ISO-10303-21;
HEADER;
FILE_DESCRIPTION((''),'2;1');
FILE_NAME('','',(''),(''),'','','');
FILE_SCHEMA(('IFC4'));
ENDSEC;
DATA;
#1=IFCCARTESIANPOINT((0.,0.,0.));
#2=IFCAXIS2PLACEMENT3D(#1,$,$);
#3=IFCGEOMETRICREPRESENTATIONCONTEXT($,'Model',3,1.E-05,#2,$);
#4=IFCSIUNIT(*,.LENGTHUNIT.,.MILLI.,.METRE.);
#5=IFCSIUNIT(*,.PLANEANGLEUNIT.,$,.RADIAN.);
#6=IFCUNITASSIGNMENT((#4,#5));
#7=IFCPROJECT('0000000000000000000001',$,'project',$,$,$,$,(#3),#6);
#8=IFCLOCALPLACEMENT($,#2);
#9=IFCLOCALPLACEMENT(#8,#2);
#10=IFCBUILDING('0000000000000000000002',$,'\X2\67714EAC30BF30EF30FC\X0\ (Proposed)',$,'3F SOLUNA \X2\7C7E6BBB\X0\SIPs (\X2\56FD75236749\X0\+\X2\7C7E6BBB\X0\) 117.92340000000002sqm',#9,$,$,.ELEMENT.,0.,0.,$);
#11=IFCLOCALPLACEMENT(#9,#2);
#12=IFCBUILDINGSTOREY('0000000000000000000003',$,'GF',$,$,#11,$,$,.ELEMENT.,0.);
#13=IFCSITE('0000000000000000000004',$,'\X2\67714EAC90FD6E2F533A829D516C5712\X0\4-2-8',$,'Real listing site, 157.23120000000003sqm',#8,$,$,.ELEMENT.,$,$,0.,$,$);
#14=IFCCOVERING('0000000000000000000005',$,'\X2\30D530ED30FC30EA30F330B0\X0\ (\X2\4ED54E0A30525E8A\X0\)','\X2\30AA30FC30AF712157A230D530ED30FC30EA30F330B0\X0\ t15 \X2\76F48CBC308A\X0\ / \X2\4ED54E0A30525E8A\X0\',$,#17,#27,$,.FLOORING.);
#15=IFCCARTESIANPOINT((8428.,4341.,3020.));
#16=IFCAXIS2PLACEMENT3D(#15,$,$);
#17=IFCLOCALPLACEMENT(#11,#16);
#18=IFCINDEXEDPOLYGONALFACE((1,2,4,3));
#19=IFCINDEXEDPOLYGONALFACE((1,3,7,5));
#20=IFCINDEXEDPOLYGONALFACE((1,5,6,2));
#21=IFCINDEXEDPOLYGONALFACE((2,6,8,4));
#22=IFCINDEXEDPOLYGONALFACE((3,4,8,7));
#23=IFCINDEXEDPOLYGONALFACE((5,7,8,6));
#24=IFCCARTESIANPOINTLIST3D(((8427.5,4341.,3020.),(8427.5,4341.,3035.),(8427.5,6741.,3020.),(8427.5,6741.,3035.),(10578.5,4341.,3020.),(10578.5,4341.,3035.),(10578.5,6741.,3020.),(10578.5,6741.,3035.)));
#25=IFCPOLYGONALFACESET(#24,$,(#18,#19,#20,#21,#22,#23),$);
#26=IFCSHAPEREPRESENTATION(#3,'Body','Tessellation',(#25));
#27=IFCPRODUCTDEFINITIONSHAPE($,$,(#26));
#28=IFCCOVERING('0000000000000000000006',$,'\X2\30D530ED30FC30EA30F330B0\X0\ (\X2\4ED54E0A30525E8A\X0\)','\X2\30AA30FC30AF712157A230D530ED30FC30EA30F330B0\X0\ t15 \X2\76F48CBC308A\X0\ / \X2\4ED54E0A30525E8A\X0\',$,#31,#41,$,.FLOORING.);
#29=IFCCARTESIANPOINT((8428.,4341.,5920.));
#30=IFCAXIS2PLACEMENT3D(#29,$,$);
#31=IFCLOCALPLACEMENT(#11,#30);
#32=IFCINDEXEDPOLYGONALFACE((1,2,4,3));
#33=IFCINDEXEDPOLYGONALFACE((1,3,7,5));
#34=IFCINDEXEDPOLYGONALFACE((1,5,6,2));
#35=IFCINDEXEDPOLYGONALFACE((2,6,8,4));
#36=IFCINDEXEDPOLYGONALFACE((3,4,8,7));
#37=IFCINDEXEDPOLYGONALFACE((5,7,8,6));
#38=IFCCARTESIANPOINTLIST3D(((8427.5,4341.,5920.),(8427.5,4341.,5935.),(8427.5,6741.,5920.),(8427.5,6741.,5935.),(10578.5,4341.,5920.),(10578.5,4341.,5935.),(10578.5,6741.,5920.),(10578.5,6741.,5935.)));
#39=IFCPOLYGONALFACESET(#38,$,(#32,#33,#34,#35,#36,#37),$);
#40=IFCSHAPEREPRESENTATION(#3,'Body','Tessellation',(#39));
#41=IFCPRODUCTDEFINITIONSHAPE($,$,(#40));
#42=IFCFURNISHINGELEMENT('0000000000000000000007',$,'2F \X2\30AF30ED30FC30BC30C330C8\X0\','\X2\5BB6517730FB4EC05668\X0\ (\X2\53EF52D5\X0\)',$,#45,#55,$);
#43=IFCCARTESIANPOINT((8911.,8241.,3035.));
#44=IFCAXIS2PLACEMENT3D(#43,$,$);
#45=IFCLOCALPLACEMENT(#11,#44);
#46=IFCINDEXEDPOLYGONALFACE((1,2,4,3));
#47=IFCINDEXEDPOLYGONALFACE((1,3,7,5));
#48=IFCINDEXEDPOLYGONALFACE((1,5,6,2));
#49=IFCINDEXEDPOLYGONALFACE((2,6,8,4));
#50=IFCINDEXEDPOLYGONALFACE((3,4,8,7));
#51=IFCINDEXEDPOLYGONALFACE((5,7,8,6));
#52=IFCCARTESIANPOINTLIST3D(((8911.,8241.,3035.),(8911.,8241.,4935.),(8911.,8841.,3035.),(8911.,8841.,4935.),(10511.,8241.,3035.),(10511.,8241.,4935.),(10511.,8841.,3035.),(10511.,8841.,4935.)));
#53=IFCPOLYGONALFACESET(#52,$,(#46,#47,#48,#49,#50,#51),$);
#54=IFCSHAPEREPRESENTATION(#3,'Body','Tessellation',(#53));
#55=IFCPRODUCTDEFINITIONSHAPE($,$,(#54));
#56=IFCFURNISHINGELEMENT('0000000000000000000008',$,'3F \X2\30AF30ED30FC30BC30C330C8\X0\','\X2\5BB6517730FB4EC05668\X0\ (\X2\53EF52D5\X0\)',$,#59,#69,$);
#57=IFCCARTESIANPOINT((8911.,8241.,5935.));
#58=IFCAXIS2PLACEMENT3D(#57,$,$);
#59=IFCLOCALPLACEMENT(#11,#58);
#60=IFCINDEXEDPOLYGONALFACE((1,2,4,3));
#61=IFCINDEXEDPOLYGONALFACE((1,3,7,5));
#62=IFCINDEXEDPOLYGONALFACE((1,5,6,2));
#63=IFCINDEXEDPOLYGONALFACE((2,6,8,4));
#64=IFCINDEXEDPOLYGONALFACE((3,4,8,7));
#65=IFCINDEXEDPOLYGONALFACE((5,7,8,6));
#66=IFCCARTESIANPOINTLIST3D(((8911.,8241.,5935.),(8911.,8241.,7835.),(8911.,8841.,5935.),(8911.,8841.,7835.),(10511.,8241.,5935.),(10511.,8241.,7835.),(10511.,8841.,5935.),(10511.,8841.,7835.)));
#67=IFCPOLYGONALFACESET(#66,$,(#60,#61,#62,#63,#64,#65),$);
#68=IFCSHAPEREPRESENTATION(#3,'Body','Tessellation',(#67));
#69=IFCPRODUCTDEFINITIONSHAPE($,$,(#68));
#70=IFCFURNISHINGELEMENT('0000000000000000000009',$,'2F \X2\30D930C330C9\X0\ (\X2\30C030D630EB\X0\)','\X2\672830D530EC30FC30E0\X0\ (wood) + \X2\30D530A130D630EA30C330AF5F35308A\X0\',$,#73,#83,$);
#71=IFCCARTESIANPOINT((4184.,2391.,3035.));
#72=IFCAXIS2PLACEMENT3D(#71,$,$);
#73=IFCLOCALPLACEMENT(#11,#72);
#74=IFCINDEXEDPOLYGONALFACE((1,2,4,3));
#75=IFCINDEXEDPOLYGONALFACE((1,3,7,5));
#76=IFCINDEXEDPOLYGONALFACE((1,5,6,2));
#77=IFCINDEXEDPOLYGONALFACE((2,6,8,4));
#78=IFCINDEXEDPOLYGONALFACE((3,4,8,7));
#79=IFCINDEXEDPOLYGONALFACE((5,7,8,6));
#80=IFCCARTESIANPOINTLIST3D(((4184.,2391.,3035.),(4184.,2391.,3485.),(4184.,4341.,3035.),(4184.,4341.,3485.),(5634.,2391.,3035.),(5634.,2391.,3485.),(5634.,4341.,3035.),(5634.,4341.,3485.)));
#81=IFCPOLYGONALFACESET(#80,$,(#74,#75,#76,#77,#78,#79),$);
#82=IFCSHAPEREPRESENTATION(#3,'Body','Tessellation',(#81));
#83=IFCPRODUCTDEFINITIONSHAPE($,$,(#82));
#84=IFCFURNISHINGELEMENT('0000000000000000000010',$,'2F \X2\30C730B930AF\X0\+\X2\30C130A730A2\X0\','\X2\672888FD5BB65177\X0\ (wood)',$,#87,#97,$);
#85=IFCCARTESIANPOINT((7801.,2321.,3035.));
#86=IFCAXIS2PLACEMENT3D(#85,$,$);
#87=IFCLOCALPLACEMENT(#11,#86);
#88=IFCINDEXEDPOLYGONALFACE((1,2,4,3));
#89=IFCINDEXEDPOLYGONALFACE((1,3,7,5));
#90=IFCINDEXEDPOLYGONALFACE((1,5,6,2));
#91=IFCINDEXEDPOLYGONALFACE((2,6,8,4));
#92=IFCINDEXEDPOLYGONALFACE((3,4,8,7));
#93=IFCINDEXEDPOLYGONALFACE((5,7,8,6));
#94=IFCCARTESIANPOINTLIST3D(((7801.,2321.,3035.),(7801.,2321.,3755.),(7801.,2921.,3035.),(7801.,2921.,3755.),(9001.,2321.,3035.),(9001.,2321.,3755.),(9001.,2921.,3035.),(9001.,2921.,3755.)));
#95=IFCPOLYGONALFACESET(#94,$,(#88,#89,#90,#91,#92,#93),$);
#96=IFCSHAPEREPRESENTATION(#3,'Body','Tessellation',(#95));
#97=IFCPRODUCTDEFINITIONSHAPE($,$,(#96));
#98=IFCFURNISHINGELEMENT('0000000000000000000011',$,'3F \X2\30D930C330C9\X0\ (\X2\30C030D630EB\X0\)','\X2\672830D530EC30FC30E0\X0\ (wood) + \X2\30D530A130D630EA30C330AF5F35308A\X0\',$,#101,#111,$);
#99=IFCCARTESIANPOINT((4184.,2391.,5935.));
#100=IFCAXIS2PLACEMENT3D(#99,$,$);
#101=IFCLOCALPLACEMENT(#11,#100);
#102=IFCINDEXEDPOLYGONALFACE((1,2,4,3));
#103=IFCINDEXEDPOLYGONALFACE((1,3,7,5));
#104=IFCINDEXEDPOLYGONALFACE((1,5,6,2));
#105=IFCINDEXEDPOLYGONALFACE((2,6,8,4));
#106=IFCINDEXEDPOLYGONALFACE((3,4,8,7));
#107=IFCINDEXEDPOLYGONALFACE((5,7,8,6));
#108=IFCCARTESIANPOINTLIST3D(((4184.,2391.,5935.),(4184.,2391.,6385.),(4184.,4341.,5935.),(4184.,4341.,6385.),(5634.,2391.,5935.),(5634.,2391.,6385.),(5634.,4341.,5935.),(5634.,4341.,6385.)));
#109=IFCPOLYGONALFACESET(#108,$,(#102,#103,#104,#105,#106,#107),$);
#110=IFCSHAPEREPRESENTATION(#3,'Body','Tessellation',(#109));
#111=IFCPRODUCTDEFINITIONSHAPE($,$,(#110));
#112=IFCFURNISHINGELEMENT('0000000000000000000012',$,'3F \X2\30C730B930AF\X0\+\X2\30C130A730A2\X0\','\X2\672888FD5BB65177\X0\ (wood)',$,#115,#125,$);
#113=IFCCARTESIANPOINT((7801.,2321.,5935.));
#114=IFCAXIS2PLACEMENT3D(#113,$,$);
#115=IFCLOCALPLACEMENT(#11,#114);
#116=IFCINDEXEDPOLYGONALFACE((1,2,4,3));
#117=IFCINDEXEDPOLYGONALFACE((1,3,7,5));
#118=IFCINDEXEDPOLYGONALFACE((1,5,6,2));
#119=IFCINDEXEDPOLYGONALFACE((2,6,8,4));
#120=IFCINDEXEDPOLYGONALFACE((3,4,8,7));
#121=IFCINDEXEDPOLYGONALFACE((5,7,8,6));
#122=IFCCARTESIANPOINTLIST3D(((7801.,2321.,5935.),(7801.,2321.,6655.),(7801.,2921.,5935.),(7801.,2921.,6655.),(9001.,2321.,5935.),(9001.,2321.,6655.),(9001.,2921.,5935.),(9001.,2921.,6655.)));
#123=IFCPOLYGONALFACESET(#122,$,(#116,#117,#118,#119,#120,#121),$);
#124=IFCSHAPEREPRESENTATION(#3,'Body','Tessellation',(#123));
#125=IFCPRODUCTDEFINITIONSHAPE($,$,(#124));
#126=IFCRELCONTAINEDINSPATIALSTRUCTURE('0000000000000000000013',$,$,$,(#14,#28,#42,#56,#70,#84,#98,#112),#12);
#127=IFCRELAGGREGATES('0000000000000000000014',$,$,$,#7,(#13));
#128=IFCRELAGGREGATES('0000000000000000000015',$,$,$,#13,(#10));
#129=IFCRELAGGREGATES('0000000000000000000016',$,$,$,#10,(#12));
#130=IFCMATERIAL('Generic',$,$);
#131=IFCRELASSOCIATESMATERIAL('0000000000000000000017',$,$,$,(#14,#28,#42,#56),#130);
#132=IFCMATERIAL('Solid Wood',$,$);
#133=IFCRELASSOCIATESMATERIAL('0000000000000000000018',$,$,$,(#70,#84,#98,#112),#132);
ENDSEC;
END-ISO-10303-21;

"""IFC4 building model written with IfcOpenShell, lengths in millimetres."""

from ifc_helpers import new_model, si_unit, frame, frame_2d, origin, place, context, project, spatial, rectangle, extrude, material, element, save


model = new_model("IFC4")

# Units and contexts
model_context = context("Model", 3, precision=1e-05, world=origin())
ifc_project = project(units=[si_unit("LENGTHUNIT", "METRE", prefix="MILLI"), si_unit("PLANEANGLEUNIT", "RADIAN")], contexts=[model_context])

# Site, building, storey
site_placement = place(None, origin())
site = spatial("IfcSite", under=ifc_project, at=site_placement, Name="東京都港区芝公園4-2-8", ObjectType="Real listing site, 157.23120000000003sqm", CompositionType="ELEMENT", RefElevation=0.0)
building_placement = place(site_placement, origin())
building = spatial("IfcBuilding", under=site, at=building_placement, Name="東京タワー (Proposed)", ObjectType="3F SOLUNA 籾殻SIPs (国産杉+籾殻) 117.92340000000002sqm", CompositionType="ELEMENT", ElevationOfRefHeight=0.0, ElevationOfTerrain=0.0)
storey_placement = place(building_placement, origin())
storey = spatial("IfcBuildingStorey", under=building, at=storey_placement, Name="GF", CompositionType="ELEMENT", Elevation=0.0)

# Shared definitions
ifc_material_1 = material(Name="Solid Wood")

# Coverings
ifc_material_2 = material(Name="Generic")
covering_1_placement = place(storey_placement, frame((8428.0, 4341.0, 3020.0)))
element("IfcCovering", 1, at=covering_1_placement, inside=storey, material=ifc_material_2, Name="フローリング (仕上げ床)", Description="オーク無垢フローリング t15 直貼り / 仕上げ床", PredefinedType="FLOORING", context=model_context, shape_type="SweptSolid", body=[
    extrude(rectangle(XDim=2151.0, YDim=2400.0, at=frame_2d((1075.0, 1200.0))), frame((8428.0, 4341.0, 3020.0)), (0.0, 0.0, 1.0), 15.0),
])
covering_2_placement = place(storey_placement, frame((8428.0, 4341.0, 5920.0)))
element("IfcCovering", 2, at=covering_2_placement, inside=storey, material=ifc_material_2, Name="フローリング (仕上げ床)", Description="オーク無垢フローリング t15 直貼り / 仕上げ床", PredefinedType="FLOORING", context=model_context, shape_type="SweptSolid", body=[
    extrude(rectangle(XDim=2151.0, YDim=2400.0, at=frame_2d((1075.0, 1200.0))), frame((8428.0, 4341.0, 5920.0)), (0.0, 0.0, 1.0), 15.0),
])

# Furnishing elements
furnishing_1_placement = place(storey_placement, frame((8911.0, 8241.0, 3035.0)))
element("IfcFurnishingElement", 3, at=furnishing_1_placement, inside=storey, material=ifc_material_2, Name="2F クローゼット", Description="家具・什器 (可動)", context=model_context, shape_type="SweptSolid", body=[
    extrude(rectangle(XDim=1600.0, YDim=600.0, at=frame_2d((800.0, 300.0))), frame((8911.0, 8241.0, 3035.0)), (0.0, 0.0, 1.0), 1900.0),
])
furnishing_2_placement = place(storey_placement, frame((8911.0, 8241.0, 5935.0)))
element("IfcFurnishingElement", 4, at=furnishing_2_placement, inside=storey, material=ifc_material_2, Name="3F クローゼット", Description="家具・什器 (可動)", context=model_context, shape_type="SweptSolid", body=[
    extrude(rectangle(XDim=1600.0, YDim=600.0, at=frame_2d((800.0, 300.0))), frame((8911.0, 8241.0, 5935.0)), (0.0, 0.0, 1.0), 1900.0),
])
furnishing_3_placement = place(storey_placement, frame((4184.0, 2391.0, 3035.0)))
element("IfcFurnishingElement", 5, at=furnishing_3_placement, inside=storey, material=ifc_material_1, Name="2F ベッド (ダブル)", Description="木フレーム (wood) + ファブリック張り", context=model_context, shape_type="SweptSolid", body=[
    extrude(rectangle(XDim=1450.0, YDim=1950.0, at=frame_2d((725.0, 975.0))), frame((4184.0, 2391.0, 3035.0)), (0.0, 0.0, 1.0), 450.0),
])
furnishing_4_placement = place(storey_placement, frame((7801.0, 2321.0, 3035.0)))
element("IfcFurnishingElement", 6, at=furnishing_4_placement, inside=storey, material=ifc_material_1, Name="2F デスク+チェア", Description="木製家具 (wood)", context=model_context, shape_type="SweptSolid", body=[
    extrude(rectangle(XDim=1200.0, YDim=600.0, at=frame_2d((600.0, 300.0))), frame((7801.0, 2321.0, 3035.0)), (0.0, 0.0, 1.0), 720.0),
])
furnishing_5_placement = place(storey_placement, frame((4184.0, 2391.0, 5935.0)))
element("IfcFurnishingElement", 7, at=furnishing_5_placement, inside=storey, material=ifc_material_1, Name="3F ベッド (ダブル)", Description="木フレーム (wood) + ファブリック張り", context=model_context, shape_type="SweptSolid", body=[
    extrude(rectangle(XDim=1450.0, YDim=1950.0, at=frame_2d((725.0, 975.0))), frame((4184.0, 2391.0, 5935.0)), (0.0, 0.0, 1.0), 450.0),
])
furnishing_6_placement = place(storey_placement, frame((7801.0, 2321.0, 5935.0)))
element("IfcFurnishingElement", 8, at=furnishing_6_placement, inside=storey, material=ifc_material_1, Name="3F デスク+チェア", Description="木製家具 (wood)", context=model_context, shape_type="SweptSolid", body=[
    extrude(rectangle(XDim=1200.0, YDim=600.0, at=frame_2d((600.0, 300.0))), frame((7801.0, 2321.0, 5935.0)), (0.0, 0.0, 1.0), 720.0),
])

save(model, "model.ifc")
